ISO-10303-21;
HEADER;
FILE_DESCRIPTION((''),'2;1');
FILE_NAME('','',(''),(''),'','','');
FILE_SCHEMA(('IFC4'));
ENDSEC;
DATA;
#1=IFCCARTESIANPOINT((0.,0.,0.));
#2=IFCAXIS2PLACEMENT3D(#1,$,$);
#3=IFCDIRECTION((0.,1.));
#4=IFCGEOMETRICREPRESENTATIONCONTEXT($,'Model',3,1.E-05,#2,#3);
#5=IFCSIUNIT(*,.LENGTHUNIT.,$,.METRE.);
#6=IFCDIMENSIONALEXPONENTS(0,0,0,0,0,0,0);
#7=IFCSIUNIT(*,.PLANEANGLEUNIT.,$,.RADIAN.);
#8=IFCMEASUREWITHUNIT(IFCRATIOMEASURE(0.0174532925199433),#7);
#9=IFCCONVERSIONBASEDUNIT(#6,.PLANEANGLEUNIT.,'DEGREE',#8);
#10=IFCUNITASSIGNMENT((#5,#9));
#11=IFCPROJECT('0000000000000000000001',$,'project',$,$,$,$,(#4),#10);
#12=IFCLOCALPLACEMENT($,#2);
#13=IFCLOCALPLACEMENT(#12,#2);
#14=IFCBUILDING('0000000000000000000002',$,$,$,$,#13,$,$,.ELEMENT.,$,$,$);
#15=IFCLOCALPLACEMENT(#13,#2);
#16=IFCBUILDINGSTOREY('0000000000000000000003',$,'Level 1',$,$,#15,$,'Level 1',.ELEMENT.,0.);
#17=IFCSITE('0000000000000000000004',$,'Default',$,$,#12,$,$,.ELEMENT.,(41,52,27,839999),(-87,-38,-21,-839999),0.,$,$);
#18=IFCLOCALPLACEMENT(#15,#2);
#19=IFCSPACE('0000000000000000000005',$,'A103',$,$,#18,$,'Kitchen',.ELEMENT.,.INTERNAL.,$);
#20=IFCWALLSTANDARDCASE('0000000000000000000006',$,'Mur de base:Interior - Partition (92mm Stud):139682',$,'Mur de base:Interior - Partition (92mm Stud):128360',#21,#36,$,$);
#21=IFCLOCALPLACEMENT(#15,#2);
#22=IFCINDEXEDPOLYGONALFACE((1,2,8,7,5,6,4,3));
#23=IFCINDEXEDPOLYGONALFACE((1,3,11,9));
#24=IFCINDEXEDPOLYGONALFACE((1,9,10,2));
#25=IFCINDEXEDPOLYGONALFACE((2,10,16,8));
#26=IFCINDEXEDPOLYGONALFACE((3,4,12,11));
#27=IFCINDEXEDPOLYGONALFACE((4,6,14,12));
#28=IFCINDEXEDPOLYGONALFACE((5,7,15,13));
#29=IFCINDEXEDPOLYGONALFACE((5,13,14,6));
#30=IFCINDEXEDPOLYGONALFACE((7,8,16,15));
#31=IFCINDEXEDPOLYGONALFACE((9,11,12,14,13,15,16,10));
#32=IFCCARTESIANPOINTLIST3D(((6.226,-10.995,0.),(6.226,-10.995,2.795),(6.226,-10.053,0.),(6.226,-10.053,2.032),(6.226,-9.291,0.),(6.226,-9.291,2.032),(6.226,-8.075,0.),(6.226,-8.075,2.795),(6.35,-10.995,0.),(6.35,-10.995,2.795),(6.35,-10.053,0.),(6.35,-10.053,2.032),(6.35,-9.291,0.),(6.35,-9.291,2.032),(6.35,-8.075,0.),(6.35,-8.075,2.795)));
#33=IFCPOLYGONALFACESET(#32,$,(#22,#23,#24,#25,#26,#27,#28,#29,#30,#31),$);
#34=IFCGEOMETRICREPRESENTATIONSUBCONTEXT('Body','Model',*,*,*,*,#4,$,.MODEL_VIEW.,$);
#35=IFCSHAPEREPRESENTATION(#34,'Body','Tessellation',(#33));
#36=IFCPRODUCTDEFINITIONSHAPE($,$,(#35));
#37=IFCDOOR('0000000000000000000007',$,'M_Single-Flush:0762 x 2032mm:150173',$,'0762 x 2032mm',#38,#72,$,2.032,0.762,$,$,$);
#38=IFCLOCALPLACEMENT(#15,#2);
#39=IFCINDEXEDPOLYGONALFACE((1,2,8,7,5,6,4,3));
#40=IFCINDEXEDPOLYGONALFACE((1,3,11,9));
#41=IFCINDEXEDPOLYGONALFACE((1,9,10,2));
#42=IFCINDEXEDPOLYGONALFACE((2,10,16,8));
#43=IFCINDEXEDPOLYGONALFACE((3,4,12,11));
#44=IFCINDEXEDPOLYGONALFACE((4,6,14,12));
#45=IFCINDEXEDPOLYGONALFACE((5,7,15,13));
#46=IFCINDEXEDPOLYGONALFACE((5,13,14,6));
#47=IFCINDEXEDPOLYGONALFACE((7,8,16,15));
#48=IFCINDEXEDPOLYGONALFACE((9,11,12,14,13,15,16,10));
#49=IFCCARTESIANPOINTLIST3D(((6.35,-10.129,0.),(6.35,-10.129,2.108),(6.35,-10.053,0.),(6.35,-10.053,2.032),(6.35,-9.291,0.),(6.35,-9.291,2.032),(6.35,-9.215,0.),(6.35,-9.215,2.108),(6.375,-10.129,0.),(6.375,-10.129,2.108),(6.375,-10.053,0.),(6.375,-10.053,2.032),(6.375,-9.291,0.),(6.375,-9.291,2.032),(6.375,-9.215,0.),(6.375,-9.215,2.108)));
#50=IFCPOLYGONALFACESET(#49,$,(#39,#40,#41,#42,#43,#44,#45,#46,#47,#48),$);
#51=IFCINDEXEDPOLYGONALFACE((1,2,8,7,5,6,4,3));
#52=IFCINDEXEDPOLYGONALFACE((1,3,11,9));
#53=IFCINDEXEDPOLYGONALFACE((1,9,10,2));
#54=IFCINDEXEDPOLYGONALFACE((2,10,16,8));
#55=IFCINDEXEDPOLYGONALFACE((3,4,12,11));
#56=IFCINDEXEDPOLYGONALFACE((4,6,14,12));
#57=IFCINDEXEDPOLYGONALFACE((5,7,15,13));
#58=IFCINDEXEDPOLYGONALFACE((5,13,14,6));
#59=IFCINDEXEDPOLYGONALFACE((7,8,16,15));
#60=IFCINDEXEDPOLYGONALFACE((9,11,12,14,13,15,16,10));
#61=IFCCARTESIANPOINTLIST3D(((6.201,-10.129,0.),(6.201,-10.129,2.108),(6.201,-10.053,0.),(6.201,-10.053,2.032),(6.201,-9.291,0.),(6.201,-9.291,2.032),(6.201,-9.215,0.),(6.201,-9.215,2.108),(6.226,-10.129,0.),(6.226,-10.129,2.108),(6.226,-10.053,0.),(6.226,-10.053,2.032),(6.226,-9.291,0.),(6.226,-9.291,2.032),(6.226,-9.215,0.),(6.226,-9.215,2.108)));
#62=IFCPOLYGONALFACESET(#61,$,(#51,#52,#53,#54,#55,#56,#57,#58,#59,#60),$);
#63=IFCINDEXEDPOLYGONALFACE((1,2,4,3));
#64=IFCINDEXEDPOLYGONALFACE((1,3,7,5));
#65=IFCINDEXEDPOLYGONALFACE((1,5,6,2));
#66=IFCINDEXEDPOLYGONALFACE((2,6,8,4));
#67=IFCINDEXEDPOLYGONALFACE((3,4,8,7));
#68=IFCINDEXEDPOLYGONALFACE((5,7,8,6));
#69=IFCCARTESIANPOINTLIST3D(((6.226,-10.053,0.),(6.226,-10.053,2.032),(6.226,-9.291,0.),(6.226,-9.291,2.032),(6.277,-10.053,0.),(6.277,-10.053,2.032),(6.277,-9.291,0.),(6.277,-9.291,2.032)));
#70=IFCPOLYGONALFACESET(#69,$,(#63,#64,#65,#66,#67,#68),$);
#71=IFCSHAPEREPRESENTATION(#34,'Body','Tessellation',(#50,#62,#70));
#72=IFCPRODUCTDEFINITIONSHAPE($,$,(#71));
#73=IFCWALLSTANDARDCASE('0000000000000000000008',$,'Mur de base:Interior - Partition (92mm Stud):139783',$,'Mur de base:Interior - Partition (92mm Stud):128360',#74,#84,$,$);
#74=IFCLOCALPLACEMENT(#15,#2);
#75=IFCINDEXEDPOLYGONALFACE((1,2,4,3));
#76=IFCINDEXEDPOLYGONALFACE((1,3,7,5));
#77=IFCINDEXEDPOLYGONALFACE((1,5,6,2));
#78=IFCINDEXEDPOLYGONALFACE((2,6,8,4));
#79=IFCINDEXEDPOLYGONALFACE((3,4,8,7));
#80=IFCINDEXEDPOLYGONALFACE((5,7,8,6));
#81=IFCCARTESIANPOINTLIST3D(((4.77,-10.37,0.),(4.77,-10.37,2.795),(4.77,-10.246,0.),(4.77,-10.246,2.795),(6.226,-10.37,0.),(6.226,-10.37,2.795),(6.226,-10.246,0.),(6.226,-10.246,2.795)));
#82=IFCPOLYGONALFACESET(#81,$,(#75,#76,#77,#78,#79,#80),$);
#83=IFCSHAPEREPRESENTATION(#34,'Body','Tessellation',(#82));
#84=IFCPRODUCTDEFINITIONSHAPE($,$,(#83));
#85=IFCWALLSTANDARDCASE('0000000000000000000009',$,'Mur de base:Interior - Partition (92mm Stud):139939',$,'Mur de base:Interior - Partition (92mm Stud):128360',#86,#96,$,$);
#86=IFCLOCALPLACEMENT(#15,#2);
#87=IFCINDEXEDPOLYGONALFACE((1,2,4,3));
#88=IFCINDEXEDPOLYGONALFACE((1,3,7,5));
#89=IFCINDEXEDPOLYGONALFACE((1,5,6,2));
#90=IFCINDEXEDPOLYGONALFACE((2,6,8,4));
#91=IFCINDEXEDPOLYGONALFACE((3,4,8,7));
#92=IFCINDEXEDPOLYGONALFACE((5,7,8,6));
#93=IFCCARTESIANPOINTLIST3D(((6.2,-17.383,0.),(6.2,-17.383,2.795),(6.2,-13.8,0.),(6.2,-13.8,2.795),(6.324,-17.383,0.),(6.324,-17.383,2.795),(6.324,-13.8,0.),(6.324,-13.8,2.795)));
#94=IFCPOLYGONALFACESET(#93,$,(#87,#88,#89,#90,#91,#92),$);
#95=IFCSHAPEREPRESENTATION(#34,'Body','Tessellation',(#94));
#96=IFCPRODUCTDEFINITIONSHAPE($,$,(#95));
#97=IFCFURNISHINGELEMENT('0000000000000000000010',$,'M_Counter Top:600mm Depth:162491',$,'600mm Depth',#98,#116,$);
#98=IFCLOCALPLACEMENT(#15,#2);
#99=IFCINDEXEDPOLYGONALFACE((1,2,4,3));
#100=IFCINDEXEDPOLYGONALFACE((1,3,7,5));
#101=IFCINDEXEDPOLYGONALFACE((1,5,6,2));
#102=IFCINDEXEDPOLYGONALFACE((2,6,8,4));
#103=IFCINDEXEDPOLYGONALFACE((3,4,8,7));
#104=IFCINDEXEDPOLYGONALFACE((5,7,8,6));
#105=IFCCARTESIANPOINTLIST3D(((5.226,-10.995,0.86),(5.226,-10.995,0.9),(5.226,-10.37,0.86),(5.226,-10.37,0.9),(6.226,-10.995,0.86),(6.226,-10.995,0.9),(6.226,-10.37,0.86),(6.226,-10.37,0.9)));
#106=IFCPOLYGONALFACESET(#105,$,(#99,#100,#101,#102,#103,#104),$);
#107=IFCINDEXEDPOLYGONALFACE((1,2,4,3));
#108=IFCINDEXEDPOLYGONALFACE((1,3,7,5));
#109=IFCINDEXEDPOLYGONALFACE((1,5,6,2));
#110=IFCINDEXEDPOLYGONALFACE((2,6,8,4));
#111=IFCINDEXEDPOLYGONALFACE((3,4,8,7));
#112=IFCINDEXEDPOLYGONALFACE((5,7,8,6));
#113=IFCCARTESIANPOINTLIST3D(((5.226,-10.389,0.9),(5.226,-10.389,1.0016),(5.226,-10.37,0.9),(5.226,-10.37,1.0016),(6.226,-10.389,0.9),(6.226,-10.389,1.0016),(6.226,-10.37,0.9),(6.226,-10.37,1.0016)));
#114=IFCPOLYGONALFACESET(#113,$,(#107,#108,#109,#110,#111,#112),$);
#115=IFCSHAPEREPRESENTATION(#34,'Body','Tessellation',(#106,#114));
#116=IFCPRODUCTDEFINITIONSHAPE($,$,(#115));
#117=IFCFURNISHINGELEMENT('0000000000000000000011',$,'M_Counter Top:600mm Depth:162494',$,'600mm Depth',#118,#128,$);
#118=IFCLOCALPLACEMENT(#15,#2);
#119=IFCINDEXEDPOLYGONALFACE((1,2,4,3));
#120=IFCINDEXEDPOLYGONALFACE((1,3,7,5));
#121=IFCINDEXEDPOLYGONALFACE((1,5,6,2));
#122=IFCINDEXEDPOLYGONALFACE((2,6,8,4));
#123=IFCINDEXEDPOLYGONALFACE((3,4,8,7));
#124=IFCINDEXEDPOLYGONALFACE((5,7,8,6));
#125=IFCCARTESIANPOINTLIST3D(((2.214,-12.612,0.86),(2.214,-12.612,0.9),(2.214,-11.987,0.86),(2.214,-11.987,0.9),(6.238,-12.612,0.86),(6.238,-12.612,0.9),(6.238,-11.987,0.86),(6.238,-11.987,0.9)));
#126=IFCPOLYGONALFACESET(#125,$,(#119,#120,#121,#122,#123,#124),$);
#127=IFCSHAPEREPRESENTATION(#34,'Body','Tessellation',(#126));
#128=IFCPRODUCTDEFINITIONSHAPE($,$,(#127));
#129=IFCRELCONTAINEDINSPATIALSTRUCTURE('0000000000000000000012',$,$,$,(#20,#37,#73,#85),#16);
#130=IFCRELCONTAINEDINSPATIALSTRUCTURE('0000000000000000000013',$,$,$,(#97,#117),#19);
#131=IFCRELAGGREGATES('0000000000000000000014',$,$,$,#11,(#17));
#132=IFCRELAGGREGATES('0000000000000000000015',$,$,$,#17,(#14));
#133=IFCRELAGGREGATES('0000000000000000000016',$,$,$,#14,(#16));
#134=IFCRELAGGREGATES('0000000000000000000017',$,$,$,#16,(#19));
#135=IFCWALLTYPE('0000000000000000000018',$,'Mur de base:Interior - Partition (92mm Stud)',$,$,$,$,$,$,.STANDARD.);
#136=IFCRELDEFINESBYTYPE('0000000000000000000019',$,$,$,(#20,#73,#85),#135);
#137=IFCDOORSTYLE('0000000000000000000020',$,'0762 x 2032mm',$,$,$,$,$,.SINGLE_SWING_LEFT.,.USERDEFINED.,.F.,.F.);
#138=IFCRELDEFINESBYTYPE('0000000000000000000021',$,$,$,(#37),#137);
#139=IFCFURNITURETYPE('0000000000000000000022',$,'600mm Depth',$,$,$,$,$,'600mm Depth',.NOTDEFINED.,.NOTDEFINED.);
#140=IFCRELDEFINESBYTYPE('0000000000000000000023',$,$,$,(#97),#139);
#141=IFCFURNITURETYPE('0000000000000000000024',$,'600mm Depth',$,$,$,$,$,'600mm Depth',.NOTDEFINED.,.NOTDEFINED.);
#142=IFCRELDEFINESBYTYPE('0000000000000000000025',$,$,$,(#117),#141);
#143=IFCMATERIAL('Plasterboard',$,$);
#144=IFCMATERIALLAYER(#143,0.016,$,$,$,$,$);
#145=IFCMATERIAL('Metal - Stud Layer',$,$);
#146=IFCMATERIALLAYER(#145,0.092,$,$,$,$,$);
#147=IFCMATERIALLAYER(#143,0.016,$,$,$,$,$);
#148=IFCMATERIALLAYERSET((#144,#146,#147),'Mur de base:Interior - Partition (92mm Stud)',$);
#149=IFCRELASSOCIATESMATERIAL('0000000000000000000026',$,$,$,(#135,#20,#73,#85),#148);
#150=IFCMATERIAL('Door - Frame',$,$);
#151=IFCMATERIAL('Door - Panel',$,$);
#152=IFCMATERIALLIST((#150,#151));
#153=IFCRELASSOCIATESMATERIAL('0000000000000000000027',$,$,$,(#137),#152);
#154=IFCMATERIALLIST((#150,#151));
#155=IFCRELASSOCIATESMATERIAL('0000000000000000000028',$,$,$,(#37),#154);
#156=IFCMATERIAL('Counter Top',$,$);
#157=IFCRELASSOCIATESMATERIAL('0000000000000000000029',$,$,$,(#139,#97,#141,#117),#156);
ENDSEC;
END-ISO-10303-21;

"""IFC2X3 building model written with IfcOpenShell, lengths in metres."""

from ifc_helpers import new_model, entity, si_unit, converted_unit, direction, frame, frame_2d, origin, place, context, subcontext, project, spatial, polyline, rectangle, outline, extrude, source, transform, mapped, material, material_list, layer, layer_set, layer_usage, type_object, type_shapes, element, fill, save


model = new_model("IFC2X3")

# Units and contexts
model_context = context("Model", 3, precision=1e-05, world=origin(), true_north=direction((0.0, 1.0)))
body_context = subcontext(model_context, "Body", "Model", "MODEL_VIEW")
ifc_project = project(units=[si_unit("LENGTHUNIT", "METRE"), converted_unit("PLANEANGLEUNIT", "DEGREE", entity("IfcRatioMeasure", 0.0174532925199433), si_unit("PLANEANGLEUNIT", "RADIAN"), dimensions=[0, 0, 0, 0, 0, 0, 0])], contexts=[model_context])

# Site, building, storey
site_placement = place(None, origin())
site = spatial("IfcSite", under=ifc_project, at=site_placement, Name="Default", CompositionType="ELEMENT", RefLatitude=(41, 52, 27, 839999), RefLongitude=(-87, -38, -21, -839999), RefElevation=0.0)
building_placement = place(site_placement, origin())
building = spatial("IfcBuilding", under=site, at=building_placement, CompositionType="ELEMENT")
storey_placement = place(building_placement, origin())
storey = spatial("IfcBuildingStorey", under=building, at=storey_placement, Name="Level 1", LongName="Level 1", CompositionType="ELEMENT", Elevation=0.0)

# Shared definitions
ifc_material_1 = material(Name="Metal - Stud Layer")
ifc_material_2 = material(Name="Plasterboard")
ifc_material_3 = material(Name="Door - Frame")
ifc_material_4 = material(Name="Door - Panel")

# Wall, opening, door
ifc_layer_1 = layer(ifc_material_2, 0.016)
ifc_layer_2 = layer(ifc_material_1, 0.092)
ifc_layer_3 = layer(ifc_material_2, 0.016)
ifc_layer_set_1 = layer_set([ifc_layer_1, ifc_layer_2, ifc_layer_3], Name="Mur de base:Interior - Partition (92mm Stud)")
ifc_layer_usage_1 = layer_usage(ifc_layer_set_1, "AXIS2", "NEGATIVE", 0.062)
wall_type_1 = type_object("IfcWallType", Name="Mur de base:Interior - Partition (92mm Stud)", PredefinedType="STANDARD", material=ifc_layer_set_1)
wall_1_placement = place(storey_placement, frame((6.288, -10.995, 0.0), z_axis=(0.0, 0.0, 1.0), x_axis=(0.0, 1.0, 0.0)))
wall_1 = element("IfcWallStandardCase", 1, at=wall_1_placement, inside=storey, type_object=wall_type_1, material=ifc_layer_usage_1, Name="Mur de base:Interior - Partition (92mm Stud):139682", ObjectType="Mur de base:Interior - Partition (92mm Stud):128360", context=body_context, shape_type="SweptSolid", body=[
    extrude(rectangle(XDim=2.92, YDim=0.124, at=frame_2d((1.46, 0.0), x_axis=(-1.0, 0.0))), origin(), (0.0, 0.0, 1.0), 2.795),
])
opening_1_placement = place(wall_1_placement, frame((0.942, -0.062, 0.0)))
opening_1 = element("IfcOpeningElement", 2, at=opening_1_placement, cuts=wall_1, ObjectType="Opening", context=body_context, shape_type="SweptSolid", body=[
    extrude(rectangle(XDim=0.762, YDim=2.032, at=frame_2d((1.016, 0.381), x_axis=(0.0, -1.0))), frame((0.0, 0.0, 0.0), z_axis=(0.0, 1.0, 0.0), x_axis=(0.0, 0.0, 1.0)), (0.0, 0.0, 1.0), 0.124),
])
ifc_material_list_1 = material_list([ifc_material_3, ifc_material_4])
ifc_material_list_2 = material_list([ifc_material_3, ifc_material_4])
door_style_1 = type_object("IfcDoorStyle", Name="0762 x 2032mm", ConstructionType="USERDEFINED", OperationType="SINGLE_SWING_LEFT", ParameterTakesPrecedence=False, Sizeable=False, material=ifc_material_list_2)
shared_shape_1 = source(origin(), body_context, "Body", "SweptSolid", [
    extrude(outline(polyline([(-1.073, -0.457), (1.035, -0.457), (1.035, -0.381), (-0.997, -0.381), (-0.997, 0.381), (1.035, 0.381), (1.035, 0.457), (-1.073, 0.457), (-1.073, -0.457)])), frame((0.381, 0.0, 1.035), z_axis=(0.0, -1.0, 0.0), x_axis=(0.0, 0.0, -1.0)), (0.0, 0.0, 1.0), 0.025),
    extrude(outline(polyline([(-0.457, -1.073), (0.457, -1.073), (0.457, 1.035), (0.381, 1.035), (0.381, -0.997), (-0.381, -0.997), (-0.381, 1.035), (-0.457, 1.035), (-0.457, -1.073)])), frame((0.381, 0.149, 1.035), z_axis=(0.0, -1.0, 0.0), x_axis=(-1.0, 0.0, 0.0)), (0.0, 0.0, 1.0), 0.025),
    extrude(rectangle(XDim=0.762, YDim=0.051, at=frame_2d((0.0, 0.0), x_axis=(1.0, 0.0))), frame((0.381, 0.0985, 0.0)), (0.0, 0.0, 1.0), 2.032),
])
type_shapes(door_style_1, [shared_shape_1])
door_1_placement = place(opening_1_placement, origin())
door_1 = element("IfcDoor", 3, at=door_1_placement, inside=storey, type_object=door_style_1, material=ifc_material_list_1, Name="M_Single-Flush:0762 x 2032mm:150173", ObjectType="0762 x 2032mm", OverallHeight=2.032, OverallWidth=0.762, context=body_context, shape_type="MappedRepresentation", body=[
    mapped(shared_shape_1, transform((0.0, 0.0, 0.0), scale=1.0)),
])
fill(opening_1, door_1)

# Walls
ifc_layer_usage_2 = layer_usage(ifc_layer_set_1, "AXIS2", "NEGATIVE", 0.062)
wall_2_placement = place(storey_placement, frame((4.77, -10.308, 0.0)))
element("IfcWallStandardCase", 4, at=wall_2_placement, inside=storey, type_object=wall_type_1, material=ifc_layer_usage_2, Name="Mur de base:Interior - Partition (92mm Stud):139783", ObjectType="Mur de base:Interior - Partition (92mm Stud):128360", context=body_context, shape_type="SweptSolid", body=[
    extrude(rectangle(XDim=1.456, YDim=0.124, at=frame_2d((0.728, 0.0), x_axis=(-1.0, 0.0))), origin(), (0.0, 0.0, 1.0), 2.795),
])
ifc_layer_usage_3 = layer_usage(ifc_layer_set_1, "AXIS2", "NEGATIVE", 0.062)
wall_3_placement = place(storey_placement, frame((6.262, -13.8, 0.0), z_axis=(0.0, 0.0, 1.0), x_axis=(0.0, -1.0, 0.0)))
element("IfcWallStandardCase", 5, at=wall_3_placement, inside=storey, type_object=wall_type_1, material=ifc_layer_usage_3, Name="Mur de base:Interior - Partition (92mm Stud):139939", ObjectType="Mur de base:Interior - Partition (92mm Stud):128360", context=body_context, shape_type="SweptSolid", body=[
    extrude(rectangle(XDim=3.583, YDim=0.124, at=frame_2d((1.7915, 0.0), x_axis=(-1.0, 0.0))), origin(), (0.0, 0.0, 1.0), 2.795),
])

# Shared definitions
space_1_placement = place(storey_placement, origin())
space_1 = spatial("IfcSpace", under=storey, at=space_1_placement, Name="A103", LongName="Kitchen", CompositionType="ELEMENT", InteriorOrExteriorSpace="INTERNAL")

# Furnishing elements
ifc_material_5 = material(Name="Counter Top")
furniture_type_1 = type_object("IfcFurnitureType", Name="600mm Depth", ElementType="600mm Depth", AssemblyPlace="NOTDEFINED", material=ifc_material_5)
shared_shape_2 = source(origin(), body_context, "Body", "SweptSolid", [
    extrude(rectangle(XDim=1.0, YDim=0.625, at=frame_2d((0.0, 0.0), x_axis=(1.0, 0.0))), frame((-0.7005, -0.3125, 0.86), z_axis=(0.0, 0.0, 1.0), x_axis=(-1.0, 0.0, 0.0)), (0.0, 0.0, 1.0), 0.04),
    extrude(rectangle(XDim=0.0191, YDim=1.0, at=frame_2d((0.0, 0.0), x_axis=(1.0, 0.0))), frame((-0.7005, -0.0095, 0.9), z_axis=(0.0, 0.0, 1.0), x_axis=(0.0, -1.0, 0.0)), (0.0, 0.0, 1.0), 0.1016),
])
type_shapes(furniture_type_1, [shared_shape_2])
furnishing_1_placement = place(space_1_placement, frame((6.4265, -10.37, 0.0)))
element("IfcFurnishingElement", 6, at=furnishing_1_placement, inside=space_1, type_object=furniture_type_1, material=ifc_material_5, Name="M_Counter Top:600mm Depth:162491", ObjectType="600mm Depth", context=body_context, shape_type="MappedRepresentation", body=[
    mapped(shared_shape_2, transform((0.0, 0.0, 0.0), scale=1.0)),
])
furniture_type_2 = type_object("IfcFurnitureType", Name="600mm Depth", ElementType="600mm Depth", AssemblyPlace="NOTDEFINED", material=ifc_material_5)
shared_shape_3 = source(origin(), body_context, "Body", "SweptSolid", [
    extrude(rectangle(XDim=4.024, YDim=0.625, at=frame_2d((0.0, 0.0), x_axis=(1.0, 0.0))), frame((0.8115, -0.3125, 0.86), z_axis=(0.0, 0.0, 1.0), x_axis=(-1.0, 0.0, 0.0)), (0.0, 0.0, 1.0), 0.04),
])
type_shapes(furniture_type_2, [shared_shape_3])
furnishing_2_placement = place(space_1_placement, frame((5.0375, -12.612, 0.0), z_axis=(0.0, 0.0, 1.0), x_axis=(-1.0, 0.0, 0.0)))
element("IfcFurnishingElement", 7, at=furnishing_2_placement, inside=space_1, type_object=furniture_type_2, material=ifc_material_5, Name="M_Counter Top:600mm Depth:162494", ObjectType="600mm Depth", context=body_context, shape_type="MappedRepresentation", body=[
    mapped(shared_shape_3, transform((0.0, 0.0, 0.0), scale=1.0)),
])

save(model, "model.ifc")
